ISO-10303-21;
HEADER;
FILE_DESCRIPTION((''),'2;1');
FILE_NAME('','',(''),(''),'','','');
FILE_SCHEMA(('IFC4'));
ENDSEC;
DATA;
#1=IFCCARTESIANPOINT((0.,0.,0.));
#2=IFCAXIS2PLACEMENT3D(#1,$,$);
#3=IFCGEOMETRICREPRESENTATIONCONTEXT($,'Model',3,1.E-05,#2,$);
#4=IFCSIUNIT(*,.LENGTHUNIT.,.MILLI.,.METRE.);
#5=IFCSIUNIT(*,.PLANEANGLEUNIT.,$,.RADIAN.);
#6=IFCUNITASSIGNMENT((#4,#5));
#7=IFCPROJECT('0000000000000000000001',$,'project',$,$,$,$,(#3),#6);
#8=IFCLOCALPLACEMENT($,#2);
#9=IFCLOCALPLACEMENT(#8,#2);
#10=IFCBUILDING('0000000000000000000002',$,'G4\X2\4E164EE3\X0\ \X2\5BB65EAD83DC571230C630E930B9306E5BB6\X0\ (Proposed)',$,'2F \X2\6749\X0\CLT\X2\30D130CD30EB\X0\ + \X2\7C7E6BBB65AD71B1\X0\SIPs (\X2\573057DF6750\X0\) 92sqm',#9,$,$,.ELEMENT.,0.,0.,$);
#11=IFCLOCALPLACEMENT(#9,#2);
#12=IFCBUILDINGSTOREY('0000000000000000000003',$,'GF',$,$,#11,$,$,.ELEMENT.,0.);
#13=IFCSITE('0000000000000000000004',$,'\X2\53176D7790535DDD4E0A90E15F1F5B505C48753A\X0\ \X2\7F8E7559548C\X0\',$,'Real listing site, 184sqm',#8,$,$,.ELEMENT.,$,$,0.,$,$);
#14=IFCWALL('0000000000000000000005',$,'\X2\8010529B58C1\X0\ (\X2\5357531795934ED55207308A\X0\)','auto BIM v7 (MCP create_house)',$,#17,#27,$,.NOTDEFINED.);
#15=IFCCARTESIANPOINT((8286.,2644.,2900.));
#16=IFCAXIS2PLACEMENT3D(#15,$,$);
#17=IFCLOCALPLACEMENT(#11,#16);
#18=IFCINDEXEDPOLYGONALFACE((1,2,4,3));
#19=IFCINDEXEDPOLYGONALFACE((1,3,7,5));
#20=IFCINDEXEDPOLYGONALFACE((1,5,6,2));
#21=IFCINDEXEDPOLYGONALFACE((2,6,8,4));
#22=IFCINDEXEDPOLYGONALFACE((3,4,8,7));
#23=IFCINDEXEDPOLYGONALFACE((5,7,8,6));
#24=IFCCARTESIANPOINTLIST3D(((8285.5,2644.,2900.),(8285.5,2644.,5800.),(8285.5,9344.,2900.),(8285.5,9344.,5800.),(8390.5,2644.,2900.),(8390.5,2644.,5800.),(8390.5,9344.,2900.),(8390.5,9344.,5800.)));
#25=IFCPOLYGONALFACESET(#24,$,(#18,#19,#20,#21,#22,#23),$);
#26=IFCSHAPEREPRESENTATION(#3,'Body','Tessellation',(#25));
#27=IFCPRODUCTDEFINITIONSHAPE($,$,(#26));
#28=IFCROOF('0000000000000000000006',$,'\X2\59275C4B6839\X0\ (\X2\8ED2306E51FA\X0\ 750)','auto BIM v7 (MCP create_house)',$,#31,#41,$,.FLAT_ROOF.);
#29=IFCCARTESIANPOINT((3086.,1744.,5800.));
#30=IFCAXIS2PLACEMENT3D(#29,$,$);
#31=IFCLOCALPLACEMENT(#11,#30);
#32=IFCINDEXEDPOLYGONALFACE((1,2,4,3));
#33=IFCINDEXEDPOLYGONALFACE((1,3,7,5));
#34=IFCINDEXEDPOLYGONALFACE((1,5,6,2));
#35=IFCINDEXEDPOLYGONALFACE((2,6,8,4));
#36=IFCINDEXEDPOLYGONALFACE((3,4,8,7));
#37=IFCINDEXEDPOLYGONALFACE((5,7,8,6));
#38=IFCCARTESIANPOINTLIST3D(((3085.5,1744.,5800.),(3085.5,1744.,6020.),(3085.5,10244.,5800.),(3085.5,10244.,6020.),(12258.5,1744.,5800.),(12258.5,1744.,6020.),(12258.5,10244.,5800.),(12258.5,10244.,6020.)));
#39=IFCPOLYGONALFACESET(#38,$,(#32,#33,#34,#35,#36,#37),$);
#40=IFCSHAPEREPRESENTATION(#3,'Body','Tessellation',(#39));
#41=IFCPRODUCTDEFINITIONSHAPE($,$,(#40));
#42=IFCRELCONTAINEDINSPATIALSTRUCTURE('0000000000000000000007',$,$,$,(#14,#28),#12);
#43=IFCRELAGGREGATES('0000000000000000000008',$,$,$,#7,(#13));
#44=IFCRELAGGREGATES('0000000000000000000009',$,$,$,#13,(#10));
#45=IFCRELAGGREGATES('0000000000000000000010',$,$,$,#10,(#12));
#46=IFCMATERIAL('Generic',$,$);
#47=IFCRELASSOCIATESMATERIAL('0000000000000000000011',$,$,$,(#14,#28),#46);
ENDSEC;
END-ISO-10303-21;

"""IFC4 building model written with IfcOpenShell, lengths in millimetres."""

from ifc_helpers import new_model, si_unit, frame, frame_2d, origin, place, context, project, spatial, rectangle, extrude, material, element, save


model = new_model("IFC4")

# Units and contexts
model_context = context("Model", 3, precision=1e-05, world=origin())
ifc_project = project(units=[si_unit("LENGTHUNIT", "METRE", prefix="MILLI"), si_unit("PLANEANGLEUNIT", "RADIAN")], contexts=[model_context])

# Site, building, storey
site_placement = place(None, origin())
site = spatial("IfcSite", under=ifc_project, at=site_placement, Name="北海道川上郡弟子屈町 美留和", ObjectType="Real listing site, 184sqm", CompositionType="ELEMENT", RefElevation=0.0)
building_placement = place(site_placement, origin())
building = spatial("IfcBuilding", under=site, at=building_placement, Name="G4世代 家庭菜園テラスの家 (Proposed)", ObjectType="2F 杉CLTパネル + 籾殻断熱SIPs (地域材) 92sqm", CompositionType="ELEMENT", ElevationOfRefHeight=0.0, ElevationOfTerrain=0.0)
storey_placement = place(building_placement, origin())
storey = spatial("IfcBuildingStorey", under=building, at=storey_placement, Name="GF", CompositionType="ELEMENT", Elevation=0.0)

# Shared definitions
ifc_material = material(Name="Generic")

# Wall
wall_1_placement = place(storey_placement, frame((8286.0, 2644.0, 2900.0)))
element("IfcWall", 1, at=wall_1_placement, inside=storey, material=ifc_material, Name="耐力壁 (南北間仕切り)", Description="auto BIM v7 (MCP create_house)", PredefinedType="NOTDEFINED", context=model_context, shape_type="SweptSolid", body=[
    extrude(rectangle(XDim=105.0, YDim=6700.0, at=frame_2d((52.0, 3350.0))), frame((8286.0, 2644.0, 2900.0)), (0.0, 0.0, 1.0), 2900.0),
])

# Roof
roof_placement = place(storey_placement, frame((3086.0, 1744.0, 5800.0)))
element("IfcRoof", 2, at=roof_placement, inside=storey, material=ifc_material, Name="大屋根 (軒の出 750)", Description="auto BIM v7 (MCP create_house)", PredefinedType="FLAT_ROOF", context=model_context, shape_type="SweptSolid", body=[
    extrude(rectangle(XDim=9173.0, YDim=8500.0, at=frame_2d((4586.0, 4250.0))), frame((3086.0, 1744.0, 5800.0)), (0.0, 0.0, 1.0), 220.0),
])

save(model, "model.ifc")
